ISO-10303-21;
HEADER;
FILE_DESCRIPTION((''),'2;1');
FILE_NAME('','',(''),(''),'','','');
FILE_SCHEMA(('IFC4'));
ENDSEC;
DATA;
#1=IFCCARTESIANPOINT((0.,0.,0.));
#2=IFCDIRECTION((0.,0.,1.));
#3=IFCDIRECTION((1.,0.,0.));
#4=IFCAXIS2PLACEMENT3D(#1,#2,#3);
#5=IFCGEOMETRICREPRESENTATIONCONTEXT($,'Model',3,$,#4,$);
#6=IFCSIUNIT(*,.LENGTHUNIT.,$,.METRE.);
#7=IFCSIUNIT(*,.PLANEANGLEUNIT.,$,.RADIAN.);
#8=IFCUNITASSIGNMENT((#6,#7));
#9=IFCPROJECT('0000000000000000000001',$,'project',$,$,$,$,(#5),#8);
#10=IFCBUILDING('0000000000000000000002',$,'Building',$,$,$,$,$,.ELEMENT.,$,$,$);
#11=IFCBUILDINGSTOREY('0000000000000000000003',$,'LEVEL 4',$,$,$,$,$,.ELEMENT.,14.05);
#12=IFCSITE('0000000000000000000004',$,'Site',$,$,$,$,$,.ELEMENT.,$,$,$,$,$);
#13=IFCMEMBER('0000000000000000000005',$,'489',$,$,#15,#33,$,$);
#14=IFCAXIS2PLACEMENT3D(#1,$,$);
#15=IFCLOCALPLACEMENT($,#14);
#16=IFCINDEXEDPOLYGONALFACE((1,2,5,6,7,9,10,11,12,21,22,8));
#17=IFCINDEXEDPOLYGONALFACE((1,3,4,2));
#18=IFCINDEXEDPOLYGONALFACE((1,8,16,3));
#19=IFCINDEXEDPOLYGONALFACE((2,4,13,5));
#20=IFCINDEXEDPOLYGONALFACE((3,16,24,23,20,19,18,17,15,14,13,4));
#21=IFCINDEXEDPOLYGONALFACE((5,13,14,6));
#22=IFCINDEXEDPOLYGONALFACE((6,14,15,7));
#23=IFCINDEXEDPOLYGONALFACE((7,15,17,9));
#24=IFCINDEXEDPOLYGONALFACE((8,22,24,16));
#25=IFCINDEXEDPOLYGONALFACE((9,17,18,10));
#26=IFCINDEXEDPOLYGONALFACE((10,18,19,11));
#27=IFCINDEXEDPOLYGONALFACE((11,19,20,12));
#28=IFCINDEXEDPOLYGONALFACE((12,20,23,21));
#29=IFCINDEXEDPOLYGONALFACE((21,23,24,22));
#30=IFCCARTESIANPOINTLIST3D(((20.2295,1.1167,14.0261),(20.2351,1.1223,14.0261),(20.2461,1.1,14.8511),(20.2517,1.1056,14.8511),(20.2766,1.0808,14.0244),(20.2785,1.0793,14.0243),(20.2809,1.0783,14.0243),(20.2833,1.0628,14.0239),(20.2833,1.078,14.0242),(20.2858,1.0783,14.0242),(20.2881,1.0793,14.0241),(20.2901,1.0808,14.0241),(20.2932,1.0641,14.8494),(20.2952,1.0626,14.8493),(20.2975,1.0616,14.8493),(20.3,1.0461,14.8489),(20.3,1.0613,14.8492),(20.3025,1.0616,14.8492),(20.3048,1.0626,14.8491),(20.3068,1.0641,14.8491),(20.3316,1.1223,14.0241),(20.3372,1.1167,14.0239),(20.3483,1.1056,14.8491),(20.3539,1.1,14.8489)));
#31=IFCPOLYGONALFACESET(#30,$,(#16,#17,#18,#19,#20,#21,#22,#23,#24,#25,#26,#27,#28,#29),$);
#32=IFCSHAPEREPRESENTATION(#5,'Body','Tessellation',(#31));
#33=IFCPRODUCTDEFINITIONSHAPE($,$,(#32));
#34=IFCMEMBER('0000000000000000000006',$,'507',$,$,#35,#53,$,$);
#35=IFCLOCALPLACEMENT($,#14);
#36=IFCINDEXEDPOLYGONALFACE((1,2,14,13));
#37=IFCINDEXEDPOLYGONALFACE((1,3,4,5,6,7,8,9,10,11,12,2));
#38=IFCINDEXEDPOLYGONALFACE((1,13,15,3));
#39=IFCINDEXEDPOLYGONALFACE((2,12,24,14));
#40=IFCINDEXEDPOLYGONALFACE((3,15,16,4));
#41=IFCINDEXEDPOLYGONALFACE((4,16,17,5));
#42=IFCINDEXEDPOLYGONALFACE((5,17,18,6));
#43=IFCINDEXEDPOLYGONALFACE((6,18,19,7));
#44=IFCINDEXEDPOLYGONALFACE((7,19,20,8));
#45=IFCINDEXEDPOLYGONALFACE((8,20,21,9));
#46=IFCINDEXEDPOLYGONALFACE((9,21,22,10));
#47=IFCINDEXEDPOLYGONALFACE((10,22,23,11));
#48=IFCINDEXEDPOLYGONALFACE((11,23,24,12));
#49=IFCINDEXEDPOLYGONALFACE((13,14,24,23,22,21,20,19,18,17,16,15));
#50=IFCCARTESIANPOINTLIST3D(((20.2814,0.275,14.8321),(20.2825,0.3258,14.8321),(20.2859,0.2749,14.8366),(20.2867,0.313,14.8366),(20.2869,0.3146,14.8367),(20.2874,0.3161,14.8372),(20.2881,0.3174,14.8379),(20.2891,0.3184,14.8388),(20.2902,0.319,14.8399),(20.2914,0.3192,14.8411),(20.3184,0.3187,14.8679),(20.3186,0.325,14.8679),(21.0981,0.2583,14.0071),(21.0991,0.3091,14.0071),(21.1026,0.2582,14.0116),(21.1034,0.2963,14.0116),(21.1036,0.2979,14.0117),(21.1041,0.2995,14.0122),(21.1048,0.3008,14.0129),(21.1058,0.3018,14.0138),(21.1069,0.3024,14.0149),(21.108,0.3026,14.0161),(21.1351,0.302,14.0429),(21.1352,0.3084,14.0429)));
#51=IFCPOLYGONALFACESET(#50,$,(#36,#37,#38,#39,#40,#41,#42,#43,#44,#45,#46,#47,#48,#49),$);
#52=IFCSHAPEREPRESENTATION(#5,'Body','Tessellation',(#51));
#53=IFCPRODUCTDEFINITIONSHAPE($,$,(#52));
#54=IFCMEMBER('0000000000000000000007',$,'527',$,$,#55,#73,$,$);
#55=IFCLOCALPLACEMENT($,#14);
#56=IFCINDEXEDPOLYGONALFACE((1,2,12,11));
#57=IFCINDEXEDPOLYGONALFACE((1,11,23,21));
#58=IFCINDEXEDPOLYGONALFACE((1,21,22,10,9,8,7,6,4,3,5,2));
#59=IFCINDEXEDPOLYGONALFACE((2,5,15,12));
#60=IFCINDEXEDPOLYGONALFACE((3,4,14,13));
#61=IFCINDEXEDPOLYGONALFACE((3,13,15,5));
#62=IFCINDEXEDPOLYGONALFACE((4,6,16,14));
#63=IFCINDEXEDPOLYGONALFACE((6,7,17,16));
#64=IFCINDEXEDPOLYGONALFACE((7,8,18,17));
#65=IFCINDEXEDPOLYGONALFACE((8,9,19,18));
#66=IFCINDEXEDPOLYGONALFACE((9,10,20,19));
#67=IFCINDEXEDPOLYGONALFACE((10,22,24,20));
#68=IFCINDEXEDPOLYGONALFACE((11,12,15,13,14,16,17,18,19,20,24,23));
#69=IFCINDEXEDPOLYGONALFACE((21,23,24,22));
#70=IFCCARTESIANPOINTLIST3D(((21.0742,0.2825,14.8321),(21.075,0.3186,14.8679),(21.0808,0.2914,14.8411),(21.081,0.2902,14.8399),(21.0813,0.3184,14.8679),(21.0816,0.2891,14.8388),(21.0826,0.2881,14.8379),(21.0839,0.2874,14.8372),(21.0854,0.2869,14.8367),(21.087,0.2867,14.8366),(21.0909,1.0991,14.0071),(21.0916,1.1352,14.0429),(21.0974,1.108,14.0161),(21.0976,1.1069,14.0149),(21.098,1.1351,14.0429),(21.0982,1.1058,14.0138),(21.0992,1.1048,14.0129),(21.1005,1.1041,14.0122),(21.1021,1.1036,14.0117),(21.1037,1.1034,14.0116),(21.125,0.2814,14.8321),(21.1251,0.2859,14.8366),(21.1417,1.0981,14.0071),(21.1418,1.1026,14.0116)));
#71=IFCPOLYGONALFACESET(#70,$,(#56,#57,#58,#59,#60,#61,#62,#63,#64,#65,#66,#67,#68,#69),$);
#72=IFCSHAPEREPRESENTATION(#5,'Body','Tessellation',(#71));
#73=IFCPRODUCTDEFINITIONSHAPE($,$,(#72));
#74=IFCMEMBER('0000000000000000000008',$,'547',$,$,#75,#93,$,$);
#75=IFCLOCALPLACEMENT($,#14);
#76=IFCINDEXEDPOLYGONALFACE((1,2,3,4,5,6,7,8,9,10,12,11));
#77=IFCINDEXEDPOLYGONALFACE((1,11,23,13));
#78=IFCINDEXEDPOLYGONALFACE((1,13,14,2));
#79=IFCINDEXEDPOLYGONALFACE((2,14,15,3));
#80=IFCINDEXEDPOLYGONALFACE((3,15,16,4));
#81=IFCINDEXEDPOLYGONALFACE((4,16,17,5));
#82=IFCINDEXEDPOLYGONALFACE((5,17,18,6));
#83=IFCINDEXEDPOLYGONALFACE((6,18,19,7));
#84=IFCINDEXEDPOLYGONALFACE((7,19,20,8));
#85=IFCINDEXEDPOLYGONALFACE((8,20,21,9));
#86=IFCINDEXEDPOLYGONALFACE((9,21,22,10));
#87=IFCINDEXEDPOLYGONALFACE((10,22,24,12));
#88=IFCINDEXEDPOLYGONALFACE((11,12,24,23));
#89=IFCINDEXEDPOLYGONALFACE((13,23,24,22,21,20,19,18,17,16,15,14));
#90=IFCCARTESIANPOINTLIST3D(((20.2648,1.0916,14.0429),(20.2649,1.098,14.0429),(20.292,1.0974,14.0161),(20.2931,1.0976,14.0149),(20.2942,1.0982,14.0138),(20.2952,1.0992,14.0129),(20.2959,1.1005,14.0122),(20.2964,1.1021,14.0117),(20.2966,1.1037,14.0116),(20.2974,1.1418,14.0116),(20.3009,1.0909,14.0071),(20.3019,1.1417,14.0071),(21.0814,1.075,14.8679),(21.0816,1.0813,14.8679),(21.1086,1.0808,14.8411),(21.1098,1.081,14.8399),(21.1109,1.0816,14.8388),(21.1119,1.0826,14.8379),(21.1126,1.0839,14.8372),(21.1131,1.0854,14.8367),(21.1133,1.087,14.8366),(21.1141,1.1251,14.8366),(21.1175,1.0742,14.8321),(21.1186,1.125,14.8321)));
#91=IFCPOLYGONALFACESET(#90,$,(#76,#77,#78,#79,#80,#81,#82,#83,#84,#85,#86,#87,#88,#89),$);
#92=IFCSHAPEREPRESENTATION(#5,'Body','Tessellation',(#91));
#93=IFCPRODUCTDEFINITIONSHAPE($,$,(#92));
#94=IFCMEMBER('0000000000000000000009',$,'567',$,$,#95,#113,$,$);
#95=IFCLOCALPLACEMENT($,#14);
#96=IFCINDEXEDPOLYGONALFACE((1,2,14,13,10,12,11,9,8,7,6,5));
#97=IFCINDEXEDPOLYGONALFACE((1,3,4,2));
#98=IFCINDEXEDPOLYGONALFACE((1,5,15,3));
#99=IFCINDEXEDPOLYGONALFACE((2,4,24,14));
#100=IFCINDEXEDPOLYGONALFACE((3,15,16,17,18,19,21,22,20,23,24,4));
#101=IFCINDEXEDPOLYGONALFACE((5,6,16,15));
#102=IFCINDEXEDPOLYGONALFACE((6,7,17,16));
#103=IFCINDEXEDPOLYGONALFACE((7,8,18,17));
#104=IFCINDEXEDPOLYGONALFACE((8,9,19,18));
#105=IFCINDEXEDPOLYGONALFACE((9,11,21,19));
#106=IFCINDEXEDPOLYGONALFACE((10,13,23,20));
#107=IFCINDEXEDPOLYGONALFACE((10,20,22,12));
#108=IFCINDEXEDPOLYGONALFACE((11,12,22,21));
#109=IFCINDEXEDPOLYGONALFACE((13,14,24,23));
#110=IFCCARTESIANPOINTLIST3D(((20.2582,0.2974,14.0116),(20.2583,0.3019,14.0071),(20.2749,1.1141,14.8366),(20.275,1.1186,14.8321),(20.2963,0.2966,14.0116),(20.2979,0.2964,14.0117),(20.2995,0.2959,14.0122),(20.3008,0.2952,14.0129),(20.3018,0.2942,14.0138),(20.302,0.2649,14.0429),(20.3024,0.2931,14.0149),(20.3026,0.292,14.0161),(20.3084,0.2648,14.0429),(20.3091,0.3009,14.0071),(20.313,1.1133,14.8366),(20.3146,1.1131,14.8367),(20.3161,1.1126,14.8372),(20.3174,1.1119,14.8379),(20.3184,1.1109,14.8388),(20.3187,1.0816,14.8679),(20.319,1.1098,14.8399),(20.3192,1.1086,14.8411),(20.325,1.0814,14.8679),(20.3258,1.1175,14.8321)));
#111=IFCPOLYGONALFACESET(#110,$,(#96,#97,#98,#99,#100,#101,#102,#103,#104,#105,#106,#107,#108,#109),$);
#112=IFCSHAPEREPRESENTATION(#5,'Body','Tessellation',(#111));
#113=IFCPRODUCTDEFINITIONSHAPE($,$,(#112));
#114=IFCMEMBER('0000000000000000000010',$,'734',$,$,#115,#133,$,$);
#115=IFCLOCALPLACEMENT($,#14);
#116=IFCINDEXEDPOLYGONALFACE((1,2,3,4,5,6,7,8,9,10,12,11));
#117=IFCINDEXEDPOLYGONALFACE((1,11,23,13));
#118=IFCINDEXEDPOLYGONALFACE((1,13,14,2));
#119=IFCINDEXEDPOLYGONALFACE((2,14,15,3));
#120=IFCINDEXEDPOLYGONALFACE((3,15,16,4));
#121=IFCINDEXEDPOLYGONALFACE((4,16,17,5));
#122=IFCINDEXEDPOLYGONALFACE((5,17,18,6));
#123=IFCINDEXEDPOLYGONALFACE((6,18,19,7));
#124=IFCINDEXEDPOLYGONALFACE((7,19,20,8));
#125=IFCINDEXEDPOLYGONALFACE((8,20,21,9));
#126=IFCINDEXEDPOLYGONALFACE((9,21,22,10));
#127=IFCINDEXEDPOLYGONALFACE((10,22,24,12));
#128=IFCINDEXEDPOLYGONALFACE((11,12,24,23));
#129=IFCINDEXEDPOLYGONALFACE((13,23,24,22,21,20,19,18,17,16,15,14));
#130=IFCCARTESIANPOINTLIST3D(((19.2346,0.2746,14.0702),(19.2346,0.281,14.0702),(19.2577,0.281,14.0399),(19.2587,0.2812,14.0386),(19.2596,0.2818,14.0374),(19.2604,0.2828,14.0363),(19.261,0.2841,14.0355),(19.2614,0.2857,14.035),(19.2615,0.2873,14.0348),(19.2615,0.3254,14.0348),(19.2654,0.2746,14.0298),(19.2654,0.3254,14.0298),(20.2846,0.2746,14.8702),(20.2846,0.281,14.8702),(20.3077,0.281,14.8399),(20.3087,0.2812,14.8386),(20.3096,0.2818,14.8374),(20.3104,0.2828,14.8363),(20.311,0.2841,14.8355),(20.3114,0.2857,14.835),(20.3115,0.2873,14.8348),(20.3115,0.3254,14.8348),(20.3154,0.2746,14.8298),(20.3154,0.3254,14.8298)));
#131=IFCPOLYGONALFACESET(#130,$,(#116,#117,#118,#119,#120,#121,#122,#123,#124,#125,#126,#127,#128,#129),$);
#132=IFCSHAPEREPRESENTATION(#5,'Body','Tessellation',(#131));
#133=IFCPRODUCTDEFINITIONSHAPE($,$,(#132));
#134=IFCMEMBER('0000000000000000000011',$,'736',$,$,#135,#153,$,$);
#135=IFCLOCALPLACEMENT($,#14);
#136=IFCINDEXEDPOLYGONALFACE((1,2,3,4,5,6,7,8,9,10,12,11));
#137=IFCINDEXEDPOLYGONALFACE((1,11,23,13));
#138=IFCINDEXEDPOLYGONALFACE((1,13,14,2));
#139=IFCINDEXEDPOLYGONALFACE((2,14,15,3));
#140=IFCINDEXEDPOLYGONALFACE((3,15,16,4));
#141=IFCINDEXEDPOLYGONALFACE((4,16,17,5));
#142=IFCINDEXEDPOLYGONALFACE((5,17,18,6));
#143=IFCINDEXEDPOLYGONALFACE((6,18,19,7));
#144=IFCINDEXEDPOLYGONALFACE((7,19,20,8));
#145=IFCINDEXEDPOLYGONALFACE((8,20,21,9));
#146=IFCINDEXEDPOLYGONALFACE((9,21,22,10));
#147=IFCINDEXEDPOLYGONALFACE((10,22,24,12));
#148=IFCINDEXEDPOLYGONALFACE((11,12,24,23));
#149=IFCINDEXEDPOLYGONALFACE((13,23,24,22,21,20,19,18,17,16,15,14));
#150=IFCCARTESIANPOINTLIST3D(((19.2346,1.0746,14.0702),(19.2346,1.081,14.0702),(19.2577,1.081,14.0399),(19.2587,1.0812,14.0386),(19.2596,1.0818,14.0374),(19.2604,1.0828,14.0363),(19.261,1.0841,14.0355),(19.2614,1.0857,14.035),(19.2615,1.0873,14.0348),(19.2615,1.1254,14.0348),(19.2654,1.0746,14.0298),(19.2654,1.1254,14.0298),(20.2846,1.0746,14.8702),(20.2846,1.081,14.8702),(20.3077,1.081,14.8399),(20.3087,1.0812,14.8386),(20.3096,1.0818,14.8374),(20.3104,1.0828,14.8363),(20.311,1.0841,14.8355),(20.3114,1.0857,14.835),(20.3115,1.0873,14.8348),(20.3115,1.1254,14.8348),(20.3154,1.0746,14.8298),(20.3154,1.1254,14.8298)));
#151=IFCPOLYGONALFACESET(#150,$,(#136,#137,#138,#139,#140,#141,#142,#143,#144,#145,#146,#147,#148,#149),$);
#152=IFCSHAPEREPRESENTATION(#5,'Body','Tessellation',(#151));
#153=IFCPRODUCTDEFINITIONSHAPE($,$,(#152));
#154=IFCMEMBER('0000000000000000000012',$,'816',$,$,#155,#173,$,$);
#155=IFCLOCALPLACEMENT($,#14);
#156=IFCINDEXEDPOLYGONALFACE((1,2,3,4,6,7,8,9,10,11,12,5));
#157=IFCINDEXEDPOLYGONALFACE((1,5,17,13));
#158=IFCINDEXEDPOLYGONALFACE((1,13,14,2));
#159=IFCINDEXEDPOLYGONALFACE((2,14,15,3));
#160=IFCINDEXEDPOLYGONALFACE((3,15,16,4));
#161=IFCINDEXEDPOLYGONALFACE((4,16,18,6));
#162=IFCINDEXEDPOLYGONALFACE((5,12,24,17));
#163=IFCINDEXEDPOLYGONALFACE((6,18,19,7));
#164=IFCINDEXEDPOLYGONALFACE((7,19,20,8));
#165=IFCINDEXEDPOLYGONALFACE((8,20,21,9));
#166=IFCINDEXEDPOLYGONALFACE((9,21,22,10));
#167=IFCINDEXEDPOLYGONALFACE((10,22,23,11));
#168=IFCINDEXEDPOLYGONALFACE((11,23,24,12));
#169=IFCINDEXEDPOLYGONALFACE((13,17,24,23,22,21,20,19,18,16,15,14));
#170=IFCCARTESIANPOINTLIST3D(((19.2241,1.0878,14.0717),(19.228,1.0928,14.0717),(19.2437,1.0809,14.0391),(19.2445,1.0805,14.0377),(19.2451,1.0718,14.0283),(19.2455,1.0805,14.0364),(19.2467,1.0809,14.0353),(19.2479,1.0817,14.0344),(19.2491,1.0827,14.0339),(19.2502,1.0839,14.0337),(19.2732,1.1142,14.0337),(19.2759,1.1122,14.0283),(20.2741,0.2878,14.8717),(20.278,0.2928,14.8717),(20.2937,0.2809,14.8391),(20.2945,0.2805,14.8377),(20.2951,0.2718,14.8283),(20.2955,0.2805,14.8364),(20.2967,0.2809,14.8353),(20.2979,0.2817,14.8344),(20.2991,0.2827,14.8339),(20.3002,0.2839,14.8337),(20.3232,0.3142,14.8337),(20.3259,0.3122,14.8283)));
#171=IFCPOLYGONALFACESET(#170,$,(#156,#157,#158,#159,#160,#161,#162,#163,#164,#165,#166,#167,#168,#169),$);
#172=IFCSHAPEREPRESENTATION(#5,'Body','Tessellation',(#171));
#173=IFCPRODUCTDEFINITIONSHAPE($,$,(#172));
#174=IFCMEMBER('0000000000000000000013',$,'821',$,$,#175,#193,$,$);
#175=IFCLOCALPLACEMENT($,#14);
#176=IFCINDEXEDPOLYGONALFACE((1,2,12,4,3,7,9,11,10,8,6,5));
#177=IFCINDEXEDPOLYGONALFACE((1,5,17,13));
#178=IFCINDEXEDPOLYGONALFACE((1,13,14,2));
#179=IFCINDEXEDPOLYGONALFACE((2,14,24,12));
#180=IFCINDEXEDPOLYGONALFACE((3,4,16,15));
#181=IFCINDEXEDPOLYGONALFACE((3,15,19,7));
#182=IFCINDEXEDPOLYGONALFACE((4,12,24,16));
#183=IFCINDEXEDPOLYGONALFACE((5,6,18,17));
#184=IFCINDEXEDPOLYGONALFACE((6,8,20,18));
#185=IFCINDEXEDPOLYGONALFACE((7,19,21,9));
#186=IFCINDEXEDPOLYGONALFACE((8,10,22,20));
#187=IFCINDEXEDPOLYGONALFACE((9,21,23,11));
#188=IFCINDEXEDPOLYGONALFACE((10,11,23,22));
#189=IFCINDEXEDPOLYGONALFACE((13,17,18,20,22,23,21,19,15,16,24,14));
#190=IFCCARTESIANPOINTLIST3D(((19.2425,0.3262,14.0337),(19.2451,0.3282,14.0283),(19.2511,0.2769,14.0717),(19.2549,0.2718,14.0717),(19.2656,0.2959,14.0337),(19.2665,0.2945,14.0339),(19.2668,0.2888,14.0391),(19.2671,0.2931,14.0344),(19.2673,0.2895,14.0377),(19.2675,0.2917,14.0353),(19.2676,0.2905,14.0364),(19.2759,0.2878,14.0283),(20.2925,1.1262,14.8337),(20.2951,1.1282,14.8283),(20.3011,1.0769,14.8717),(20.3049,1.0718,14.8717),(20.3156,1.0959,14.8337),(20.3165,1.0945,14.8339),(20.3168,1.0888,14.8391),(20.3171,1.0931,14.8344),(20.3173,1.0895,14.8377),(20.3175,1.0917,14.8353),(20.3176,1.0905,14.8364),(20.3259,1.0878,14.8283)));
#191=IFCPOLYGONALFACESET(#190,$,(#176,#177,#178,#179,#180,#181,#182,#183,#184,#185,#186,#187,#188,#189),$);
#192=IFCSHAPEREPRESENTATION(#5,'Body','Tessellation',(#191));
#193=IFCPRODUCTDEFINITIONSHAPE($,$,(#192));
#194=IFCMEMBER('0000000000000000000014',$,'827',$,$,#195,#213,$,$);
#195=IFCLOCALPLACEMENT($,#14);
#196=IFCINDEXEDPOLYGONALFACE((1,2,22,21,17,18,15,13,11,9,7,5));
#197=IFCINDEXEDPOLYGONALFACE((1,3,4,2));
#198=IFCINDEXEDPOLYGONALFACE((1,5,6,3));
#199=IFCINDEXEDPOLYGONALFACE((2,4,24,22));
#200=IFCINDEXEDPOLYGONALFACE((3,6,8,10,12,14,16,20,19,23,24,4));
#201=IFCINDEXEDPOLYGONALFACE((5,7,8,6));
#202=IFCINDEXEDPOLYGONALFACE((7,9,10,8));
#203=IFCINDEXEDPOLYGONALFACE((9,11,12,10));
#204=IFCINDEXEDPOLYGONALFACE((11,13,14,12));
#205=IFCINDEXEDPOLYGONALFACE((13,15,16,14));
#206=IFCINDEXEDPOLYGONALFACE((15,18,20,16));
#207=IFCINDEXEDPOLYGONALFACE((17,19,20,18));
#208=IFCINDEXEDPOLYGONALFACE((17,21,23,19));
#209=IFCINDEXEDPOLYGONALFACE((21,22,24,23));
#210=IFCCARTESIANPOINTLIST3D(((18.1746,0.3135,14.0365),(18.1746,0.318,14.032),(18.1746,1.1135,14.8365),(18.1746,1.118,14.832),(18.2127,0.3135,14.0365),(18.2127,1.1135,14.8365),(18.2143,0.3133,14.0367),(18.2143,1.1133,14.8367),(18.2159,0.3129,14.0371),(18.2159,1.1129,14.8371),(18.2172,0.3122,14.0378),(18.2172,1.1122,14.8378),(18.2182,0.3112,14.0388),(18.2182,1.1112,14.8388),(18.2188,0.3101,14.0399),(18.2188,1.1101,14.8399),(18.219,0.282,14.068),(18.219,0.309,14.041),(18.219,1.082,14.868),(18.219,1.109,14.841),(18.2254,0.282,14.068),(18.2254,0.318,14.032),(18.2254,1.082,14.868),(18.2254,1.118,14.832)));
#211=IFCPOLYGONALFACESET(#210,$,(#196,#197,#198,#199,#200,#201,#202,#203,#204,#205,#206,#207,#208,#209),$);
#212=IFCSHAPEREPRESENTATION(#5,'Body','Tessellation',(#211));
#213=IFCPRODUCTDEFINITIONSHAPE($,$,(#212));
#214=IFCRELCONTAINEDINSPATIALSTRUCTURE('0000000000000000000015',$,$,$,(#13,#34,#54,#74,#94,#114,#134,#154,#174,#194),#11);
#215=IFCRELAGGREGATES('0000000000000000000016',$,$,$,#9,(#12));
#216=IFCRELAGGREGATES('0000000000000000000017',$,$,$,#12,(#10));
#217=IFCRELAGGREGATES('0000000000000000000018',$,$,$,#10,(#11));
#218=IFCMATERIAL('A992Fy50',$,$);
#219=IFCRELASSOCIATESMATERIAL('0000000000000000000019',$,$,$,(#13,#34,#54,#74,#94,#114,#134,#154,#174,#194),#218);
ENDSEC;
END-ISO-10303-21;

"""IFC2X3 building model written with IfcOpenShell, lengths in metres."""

from ifc_helpers import new_model, si_unit, frame, origin_with_axes, origin_2d_with_axis, place, context, project, spatial, l_section, extrude, material, element, save


model = new_model("IFC2X3")

# Units and contexts
model_context = context("Model", 3, world=origin_with_axes())
ifc_project = project(units=[si_unit("LENGTHUNIT", "METRE"), si_unit("PLANEANGLEUNIT", "RADIAN")], contexts=[model_context])

# Site, building, storey
site = spatial("IfcSite", under=ifc_project, Name="Site", CompositionType="ELEMENT")
building = spatial("IfcBuilding", under=site, Name="Building", CompositionType="ELEMENT")
storey = spatial("IfcBuildingStorey", under=building, Name="LEVEL 4", CompositionType="ELEMENT", Elevation=14.05)

# Shared definitions
ifc_material = material(Name="A992Fy50")

# Members
for number, where, z_axis, x_axis, name in (
    (1, (20.2833, 1.1167, 14.025), (0.020194, -0.020194, 0.999592), (0.707107, 0.707107, 0.0), "489"),
):
    element("IfcMember", number, at=place(None, frame(where, z_axis=z_axis, x_axis=x_axis)), inside=storey, material=ifc_material, Name=name, context=model_context, shape_type="SweptSolid", body=[
        extrude(l_section(Depth=0.0762, Width=0.0762, Thickness=0.0079, FilletRadius=0.0096, at=origin_2d_with_axis()), origin_with_axes(), (0.0, 0.0, 1.0), 0.8253),
    ])
for number, where, z_axis, x_axis, name in (
    (2, (21.1167, 0.2833, 14.025), (-0.703436, 0.014356, 0.710614), (-0.020404, -0.999792, 0.0), "507"),
    (3, (21.1167, 1.1167, 14.025), (-0.014356, -0.703436, 0.710614), (0.999792, -0.020404, 0.0), "527"),
    (4, (20.2833, 1.1167, 14.025), (0.703436, -0.014356, 0.710614), (0.020404, 0.999792, 0.0), "547"),
    (5, (20.2833, 0.2833, 14.025), (0.014356, 0.703436, 0.710614), (-0.999792, 0.020404, 0.0), "567"),
):
    element("IfcMember", number, at=place(None, frame(where, z_axis=z_axis, x_axis=x_axis)), inside=storey, material=ifc_material, Name=name, context=model_context, shape_type="SweptSolid", body=[
        extrude(l_section(Depth=0.0508, Width=0.0508, Thickness=0.0063, FilletRadius=0.0063, at=origin_2d_with_axis()), origin_with_axes(), (0.0, 0.0, 1.0), 1.161),
    ])
for number, where, z_axis, x_axis, name in (
    (6, (19.25, 0.3, 14.05), (0.795432, 0.0, 0.606043), (0.0, 1.0, 0.0), "734"),
    (7, (19.25, 1.1, 14.05), (0.795432, 0.0, 0.606043), (0.0, 1.0, 0.0), "736"),
):
    element("IfcMember", number, at=place(None, frame(where, z_axis=z_axis, x_axis=x_axis)), inside=storey, material=ifc_material, Name=name, context=model_context, shape_type="SweptSolid", body=[
        extrude(l_section(Depth=0.0508, Width=0.0508, Thickness=0.0063, FilletRadius=0.0063, at=origin_2d_with_axis()), origin_with_axes(), (0.0, 0.0, 1.0), 1.32),
    ])
for number, where, z_axis, x_axis, name in (
    (8, (19.25, 1.1, 14.05), (0.680257, -0.518291, 0.518291), (0.606043, 0.795432, 0.0), "816"),
    (9, (19.25, 0.3, 14.05), (0.680257, 0.518291, 0.518291), (-0.606043, 0.795432, 0.0), "821"),
):
    element("IfcMember", number, at=place(None, frame(where, z_axis=z_axis, x_axis=x_axis)), inside=storey, material=ifc_material, Name=name, context=model_context, shape_type="SweptSolid", body=[
        extrude(l_section(Depth=0.0508, Width=0.0508, Thickness=0.0063, FilletRadius=0.0063, at=origin_2d_with_axis()), origin_with_axes(), (0.0, 0.0, 1.0), 1.5435),
    ])
for number, where, z_axis, x_axis, name in (
    (10, (18.2, 0.3, 14.05), (0.0, 0.707107, 0.707107), (-1.0, 0.0, 0.0), "827"),
):
    element("IfcMember", number, at=place(None, frame(where, z_axis=z_axis, x_axis=x_axis)), inside=storey, material=ifc_material, Name=name, context=model_context, shape_type="SweptSolid", body=[
        extrude(l_section(Depth=0.0508, Width=0.0508, Thickness=0.0063, FilletRadius=0.0063, at=origin_2d_with_axis()), origin_with_axes(), (0.0, 0.0, 1.0), 1.1314),
    ])

save(model, "model.ifc")
